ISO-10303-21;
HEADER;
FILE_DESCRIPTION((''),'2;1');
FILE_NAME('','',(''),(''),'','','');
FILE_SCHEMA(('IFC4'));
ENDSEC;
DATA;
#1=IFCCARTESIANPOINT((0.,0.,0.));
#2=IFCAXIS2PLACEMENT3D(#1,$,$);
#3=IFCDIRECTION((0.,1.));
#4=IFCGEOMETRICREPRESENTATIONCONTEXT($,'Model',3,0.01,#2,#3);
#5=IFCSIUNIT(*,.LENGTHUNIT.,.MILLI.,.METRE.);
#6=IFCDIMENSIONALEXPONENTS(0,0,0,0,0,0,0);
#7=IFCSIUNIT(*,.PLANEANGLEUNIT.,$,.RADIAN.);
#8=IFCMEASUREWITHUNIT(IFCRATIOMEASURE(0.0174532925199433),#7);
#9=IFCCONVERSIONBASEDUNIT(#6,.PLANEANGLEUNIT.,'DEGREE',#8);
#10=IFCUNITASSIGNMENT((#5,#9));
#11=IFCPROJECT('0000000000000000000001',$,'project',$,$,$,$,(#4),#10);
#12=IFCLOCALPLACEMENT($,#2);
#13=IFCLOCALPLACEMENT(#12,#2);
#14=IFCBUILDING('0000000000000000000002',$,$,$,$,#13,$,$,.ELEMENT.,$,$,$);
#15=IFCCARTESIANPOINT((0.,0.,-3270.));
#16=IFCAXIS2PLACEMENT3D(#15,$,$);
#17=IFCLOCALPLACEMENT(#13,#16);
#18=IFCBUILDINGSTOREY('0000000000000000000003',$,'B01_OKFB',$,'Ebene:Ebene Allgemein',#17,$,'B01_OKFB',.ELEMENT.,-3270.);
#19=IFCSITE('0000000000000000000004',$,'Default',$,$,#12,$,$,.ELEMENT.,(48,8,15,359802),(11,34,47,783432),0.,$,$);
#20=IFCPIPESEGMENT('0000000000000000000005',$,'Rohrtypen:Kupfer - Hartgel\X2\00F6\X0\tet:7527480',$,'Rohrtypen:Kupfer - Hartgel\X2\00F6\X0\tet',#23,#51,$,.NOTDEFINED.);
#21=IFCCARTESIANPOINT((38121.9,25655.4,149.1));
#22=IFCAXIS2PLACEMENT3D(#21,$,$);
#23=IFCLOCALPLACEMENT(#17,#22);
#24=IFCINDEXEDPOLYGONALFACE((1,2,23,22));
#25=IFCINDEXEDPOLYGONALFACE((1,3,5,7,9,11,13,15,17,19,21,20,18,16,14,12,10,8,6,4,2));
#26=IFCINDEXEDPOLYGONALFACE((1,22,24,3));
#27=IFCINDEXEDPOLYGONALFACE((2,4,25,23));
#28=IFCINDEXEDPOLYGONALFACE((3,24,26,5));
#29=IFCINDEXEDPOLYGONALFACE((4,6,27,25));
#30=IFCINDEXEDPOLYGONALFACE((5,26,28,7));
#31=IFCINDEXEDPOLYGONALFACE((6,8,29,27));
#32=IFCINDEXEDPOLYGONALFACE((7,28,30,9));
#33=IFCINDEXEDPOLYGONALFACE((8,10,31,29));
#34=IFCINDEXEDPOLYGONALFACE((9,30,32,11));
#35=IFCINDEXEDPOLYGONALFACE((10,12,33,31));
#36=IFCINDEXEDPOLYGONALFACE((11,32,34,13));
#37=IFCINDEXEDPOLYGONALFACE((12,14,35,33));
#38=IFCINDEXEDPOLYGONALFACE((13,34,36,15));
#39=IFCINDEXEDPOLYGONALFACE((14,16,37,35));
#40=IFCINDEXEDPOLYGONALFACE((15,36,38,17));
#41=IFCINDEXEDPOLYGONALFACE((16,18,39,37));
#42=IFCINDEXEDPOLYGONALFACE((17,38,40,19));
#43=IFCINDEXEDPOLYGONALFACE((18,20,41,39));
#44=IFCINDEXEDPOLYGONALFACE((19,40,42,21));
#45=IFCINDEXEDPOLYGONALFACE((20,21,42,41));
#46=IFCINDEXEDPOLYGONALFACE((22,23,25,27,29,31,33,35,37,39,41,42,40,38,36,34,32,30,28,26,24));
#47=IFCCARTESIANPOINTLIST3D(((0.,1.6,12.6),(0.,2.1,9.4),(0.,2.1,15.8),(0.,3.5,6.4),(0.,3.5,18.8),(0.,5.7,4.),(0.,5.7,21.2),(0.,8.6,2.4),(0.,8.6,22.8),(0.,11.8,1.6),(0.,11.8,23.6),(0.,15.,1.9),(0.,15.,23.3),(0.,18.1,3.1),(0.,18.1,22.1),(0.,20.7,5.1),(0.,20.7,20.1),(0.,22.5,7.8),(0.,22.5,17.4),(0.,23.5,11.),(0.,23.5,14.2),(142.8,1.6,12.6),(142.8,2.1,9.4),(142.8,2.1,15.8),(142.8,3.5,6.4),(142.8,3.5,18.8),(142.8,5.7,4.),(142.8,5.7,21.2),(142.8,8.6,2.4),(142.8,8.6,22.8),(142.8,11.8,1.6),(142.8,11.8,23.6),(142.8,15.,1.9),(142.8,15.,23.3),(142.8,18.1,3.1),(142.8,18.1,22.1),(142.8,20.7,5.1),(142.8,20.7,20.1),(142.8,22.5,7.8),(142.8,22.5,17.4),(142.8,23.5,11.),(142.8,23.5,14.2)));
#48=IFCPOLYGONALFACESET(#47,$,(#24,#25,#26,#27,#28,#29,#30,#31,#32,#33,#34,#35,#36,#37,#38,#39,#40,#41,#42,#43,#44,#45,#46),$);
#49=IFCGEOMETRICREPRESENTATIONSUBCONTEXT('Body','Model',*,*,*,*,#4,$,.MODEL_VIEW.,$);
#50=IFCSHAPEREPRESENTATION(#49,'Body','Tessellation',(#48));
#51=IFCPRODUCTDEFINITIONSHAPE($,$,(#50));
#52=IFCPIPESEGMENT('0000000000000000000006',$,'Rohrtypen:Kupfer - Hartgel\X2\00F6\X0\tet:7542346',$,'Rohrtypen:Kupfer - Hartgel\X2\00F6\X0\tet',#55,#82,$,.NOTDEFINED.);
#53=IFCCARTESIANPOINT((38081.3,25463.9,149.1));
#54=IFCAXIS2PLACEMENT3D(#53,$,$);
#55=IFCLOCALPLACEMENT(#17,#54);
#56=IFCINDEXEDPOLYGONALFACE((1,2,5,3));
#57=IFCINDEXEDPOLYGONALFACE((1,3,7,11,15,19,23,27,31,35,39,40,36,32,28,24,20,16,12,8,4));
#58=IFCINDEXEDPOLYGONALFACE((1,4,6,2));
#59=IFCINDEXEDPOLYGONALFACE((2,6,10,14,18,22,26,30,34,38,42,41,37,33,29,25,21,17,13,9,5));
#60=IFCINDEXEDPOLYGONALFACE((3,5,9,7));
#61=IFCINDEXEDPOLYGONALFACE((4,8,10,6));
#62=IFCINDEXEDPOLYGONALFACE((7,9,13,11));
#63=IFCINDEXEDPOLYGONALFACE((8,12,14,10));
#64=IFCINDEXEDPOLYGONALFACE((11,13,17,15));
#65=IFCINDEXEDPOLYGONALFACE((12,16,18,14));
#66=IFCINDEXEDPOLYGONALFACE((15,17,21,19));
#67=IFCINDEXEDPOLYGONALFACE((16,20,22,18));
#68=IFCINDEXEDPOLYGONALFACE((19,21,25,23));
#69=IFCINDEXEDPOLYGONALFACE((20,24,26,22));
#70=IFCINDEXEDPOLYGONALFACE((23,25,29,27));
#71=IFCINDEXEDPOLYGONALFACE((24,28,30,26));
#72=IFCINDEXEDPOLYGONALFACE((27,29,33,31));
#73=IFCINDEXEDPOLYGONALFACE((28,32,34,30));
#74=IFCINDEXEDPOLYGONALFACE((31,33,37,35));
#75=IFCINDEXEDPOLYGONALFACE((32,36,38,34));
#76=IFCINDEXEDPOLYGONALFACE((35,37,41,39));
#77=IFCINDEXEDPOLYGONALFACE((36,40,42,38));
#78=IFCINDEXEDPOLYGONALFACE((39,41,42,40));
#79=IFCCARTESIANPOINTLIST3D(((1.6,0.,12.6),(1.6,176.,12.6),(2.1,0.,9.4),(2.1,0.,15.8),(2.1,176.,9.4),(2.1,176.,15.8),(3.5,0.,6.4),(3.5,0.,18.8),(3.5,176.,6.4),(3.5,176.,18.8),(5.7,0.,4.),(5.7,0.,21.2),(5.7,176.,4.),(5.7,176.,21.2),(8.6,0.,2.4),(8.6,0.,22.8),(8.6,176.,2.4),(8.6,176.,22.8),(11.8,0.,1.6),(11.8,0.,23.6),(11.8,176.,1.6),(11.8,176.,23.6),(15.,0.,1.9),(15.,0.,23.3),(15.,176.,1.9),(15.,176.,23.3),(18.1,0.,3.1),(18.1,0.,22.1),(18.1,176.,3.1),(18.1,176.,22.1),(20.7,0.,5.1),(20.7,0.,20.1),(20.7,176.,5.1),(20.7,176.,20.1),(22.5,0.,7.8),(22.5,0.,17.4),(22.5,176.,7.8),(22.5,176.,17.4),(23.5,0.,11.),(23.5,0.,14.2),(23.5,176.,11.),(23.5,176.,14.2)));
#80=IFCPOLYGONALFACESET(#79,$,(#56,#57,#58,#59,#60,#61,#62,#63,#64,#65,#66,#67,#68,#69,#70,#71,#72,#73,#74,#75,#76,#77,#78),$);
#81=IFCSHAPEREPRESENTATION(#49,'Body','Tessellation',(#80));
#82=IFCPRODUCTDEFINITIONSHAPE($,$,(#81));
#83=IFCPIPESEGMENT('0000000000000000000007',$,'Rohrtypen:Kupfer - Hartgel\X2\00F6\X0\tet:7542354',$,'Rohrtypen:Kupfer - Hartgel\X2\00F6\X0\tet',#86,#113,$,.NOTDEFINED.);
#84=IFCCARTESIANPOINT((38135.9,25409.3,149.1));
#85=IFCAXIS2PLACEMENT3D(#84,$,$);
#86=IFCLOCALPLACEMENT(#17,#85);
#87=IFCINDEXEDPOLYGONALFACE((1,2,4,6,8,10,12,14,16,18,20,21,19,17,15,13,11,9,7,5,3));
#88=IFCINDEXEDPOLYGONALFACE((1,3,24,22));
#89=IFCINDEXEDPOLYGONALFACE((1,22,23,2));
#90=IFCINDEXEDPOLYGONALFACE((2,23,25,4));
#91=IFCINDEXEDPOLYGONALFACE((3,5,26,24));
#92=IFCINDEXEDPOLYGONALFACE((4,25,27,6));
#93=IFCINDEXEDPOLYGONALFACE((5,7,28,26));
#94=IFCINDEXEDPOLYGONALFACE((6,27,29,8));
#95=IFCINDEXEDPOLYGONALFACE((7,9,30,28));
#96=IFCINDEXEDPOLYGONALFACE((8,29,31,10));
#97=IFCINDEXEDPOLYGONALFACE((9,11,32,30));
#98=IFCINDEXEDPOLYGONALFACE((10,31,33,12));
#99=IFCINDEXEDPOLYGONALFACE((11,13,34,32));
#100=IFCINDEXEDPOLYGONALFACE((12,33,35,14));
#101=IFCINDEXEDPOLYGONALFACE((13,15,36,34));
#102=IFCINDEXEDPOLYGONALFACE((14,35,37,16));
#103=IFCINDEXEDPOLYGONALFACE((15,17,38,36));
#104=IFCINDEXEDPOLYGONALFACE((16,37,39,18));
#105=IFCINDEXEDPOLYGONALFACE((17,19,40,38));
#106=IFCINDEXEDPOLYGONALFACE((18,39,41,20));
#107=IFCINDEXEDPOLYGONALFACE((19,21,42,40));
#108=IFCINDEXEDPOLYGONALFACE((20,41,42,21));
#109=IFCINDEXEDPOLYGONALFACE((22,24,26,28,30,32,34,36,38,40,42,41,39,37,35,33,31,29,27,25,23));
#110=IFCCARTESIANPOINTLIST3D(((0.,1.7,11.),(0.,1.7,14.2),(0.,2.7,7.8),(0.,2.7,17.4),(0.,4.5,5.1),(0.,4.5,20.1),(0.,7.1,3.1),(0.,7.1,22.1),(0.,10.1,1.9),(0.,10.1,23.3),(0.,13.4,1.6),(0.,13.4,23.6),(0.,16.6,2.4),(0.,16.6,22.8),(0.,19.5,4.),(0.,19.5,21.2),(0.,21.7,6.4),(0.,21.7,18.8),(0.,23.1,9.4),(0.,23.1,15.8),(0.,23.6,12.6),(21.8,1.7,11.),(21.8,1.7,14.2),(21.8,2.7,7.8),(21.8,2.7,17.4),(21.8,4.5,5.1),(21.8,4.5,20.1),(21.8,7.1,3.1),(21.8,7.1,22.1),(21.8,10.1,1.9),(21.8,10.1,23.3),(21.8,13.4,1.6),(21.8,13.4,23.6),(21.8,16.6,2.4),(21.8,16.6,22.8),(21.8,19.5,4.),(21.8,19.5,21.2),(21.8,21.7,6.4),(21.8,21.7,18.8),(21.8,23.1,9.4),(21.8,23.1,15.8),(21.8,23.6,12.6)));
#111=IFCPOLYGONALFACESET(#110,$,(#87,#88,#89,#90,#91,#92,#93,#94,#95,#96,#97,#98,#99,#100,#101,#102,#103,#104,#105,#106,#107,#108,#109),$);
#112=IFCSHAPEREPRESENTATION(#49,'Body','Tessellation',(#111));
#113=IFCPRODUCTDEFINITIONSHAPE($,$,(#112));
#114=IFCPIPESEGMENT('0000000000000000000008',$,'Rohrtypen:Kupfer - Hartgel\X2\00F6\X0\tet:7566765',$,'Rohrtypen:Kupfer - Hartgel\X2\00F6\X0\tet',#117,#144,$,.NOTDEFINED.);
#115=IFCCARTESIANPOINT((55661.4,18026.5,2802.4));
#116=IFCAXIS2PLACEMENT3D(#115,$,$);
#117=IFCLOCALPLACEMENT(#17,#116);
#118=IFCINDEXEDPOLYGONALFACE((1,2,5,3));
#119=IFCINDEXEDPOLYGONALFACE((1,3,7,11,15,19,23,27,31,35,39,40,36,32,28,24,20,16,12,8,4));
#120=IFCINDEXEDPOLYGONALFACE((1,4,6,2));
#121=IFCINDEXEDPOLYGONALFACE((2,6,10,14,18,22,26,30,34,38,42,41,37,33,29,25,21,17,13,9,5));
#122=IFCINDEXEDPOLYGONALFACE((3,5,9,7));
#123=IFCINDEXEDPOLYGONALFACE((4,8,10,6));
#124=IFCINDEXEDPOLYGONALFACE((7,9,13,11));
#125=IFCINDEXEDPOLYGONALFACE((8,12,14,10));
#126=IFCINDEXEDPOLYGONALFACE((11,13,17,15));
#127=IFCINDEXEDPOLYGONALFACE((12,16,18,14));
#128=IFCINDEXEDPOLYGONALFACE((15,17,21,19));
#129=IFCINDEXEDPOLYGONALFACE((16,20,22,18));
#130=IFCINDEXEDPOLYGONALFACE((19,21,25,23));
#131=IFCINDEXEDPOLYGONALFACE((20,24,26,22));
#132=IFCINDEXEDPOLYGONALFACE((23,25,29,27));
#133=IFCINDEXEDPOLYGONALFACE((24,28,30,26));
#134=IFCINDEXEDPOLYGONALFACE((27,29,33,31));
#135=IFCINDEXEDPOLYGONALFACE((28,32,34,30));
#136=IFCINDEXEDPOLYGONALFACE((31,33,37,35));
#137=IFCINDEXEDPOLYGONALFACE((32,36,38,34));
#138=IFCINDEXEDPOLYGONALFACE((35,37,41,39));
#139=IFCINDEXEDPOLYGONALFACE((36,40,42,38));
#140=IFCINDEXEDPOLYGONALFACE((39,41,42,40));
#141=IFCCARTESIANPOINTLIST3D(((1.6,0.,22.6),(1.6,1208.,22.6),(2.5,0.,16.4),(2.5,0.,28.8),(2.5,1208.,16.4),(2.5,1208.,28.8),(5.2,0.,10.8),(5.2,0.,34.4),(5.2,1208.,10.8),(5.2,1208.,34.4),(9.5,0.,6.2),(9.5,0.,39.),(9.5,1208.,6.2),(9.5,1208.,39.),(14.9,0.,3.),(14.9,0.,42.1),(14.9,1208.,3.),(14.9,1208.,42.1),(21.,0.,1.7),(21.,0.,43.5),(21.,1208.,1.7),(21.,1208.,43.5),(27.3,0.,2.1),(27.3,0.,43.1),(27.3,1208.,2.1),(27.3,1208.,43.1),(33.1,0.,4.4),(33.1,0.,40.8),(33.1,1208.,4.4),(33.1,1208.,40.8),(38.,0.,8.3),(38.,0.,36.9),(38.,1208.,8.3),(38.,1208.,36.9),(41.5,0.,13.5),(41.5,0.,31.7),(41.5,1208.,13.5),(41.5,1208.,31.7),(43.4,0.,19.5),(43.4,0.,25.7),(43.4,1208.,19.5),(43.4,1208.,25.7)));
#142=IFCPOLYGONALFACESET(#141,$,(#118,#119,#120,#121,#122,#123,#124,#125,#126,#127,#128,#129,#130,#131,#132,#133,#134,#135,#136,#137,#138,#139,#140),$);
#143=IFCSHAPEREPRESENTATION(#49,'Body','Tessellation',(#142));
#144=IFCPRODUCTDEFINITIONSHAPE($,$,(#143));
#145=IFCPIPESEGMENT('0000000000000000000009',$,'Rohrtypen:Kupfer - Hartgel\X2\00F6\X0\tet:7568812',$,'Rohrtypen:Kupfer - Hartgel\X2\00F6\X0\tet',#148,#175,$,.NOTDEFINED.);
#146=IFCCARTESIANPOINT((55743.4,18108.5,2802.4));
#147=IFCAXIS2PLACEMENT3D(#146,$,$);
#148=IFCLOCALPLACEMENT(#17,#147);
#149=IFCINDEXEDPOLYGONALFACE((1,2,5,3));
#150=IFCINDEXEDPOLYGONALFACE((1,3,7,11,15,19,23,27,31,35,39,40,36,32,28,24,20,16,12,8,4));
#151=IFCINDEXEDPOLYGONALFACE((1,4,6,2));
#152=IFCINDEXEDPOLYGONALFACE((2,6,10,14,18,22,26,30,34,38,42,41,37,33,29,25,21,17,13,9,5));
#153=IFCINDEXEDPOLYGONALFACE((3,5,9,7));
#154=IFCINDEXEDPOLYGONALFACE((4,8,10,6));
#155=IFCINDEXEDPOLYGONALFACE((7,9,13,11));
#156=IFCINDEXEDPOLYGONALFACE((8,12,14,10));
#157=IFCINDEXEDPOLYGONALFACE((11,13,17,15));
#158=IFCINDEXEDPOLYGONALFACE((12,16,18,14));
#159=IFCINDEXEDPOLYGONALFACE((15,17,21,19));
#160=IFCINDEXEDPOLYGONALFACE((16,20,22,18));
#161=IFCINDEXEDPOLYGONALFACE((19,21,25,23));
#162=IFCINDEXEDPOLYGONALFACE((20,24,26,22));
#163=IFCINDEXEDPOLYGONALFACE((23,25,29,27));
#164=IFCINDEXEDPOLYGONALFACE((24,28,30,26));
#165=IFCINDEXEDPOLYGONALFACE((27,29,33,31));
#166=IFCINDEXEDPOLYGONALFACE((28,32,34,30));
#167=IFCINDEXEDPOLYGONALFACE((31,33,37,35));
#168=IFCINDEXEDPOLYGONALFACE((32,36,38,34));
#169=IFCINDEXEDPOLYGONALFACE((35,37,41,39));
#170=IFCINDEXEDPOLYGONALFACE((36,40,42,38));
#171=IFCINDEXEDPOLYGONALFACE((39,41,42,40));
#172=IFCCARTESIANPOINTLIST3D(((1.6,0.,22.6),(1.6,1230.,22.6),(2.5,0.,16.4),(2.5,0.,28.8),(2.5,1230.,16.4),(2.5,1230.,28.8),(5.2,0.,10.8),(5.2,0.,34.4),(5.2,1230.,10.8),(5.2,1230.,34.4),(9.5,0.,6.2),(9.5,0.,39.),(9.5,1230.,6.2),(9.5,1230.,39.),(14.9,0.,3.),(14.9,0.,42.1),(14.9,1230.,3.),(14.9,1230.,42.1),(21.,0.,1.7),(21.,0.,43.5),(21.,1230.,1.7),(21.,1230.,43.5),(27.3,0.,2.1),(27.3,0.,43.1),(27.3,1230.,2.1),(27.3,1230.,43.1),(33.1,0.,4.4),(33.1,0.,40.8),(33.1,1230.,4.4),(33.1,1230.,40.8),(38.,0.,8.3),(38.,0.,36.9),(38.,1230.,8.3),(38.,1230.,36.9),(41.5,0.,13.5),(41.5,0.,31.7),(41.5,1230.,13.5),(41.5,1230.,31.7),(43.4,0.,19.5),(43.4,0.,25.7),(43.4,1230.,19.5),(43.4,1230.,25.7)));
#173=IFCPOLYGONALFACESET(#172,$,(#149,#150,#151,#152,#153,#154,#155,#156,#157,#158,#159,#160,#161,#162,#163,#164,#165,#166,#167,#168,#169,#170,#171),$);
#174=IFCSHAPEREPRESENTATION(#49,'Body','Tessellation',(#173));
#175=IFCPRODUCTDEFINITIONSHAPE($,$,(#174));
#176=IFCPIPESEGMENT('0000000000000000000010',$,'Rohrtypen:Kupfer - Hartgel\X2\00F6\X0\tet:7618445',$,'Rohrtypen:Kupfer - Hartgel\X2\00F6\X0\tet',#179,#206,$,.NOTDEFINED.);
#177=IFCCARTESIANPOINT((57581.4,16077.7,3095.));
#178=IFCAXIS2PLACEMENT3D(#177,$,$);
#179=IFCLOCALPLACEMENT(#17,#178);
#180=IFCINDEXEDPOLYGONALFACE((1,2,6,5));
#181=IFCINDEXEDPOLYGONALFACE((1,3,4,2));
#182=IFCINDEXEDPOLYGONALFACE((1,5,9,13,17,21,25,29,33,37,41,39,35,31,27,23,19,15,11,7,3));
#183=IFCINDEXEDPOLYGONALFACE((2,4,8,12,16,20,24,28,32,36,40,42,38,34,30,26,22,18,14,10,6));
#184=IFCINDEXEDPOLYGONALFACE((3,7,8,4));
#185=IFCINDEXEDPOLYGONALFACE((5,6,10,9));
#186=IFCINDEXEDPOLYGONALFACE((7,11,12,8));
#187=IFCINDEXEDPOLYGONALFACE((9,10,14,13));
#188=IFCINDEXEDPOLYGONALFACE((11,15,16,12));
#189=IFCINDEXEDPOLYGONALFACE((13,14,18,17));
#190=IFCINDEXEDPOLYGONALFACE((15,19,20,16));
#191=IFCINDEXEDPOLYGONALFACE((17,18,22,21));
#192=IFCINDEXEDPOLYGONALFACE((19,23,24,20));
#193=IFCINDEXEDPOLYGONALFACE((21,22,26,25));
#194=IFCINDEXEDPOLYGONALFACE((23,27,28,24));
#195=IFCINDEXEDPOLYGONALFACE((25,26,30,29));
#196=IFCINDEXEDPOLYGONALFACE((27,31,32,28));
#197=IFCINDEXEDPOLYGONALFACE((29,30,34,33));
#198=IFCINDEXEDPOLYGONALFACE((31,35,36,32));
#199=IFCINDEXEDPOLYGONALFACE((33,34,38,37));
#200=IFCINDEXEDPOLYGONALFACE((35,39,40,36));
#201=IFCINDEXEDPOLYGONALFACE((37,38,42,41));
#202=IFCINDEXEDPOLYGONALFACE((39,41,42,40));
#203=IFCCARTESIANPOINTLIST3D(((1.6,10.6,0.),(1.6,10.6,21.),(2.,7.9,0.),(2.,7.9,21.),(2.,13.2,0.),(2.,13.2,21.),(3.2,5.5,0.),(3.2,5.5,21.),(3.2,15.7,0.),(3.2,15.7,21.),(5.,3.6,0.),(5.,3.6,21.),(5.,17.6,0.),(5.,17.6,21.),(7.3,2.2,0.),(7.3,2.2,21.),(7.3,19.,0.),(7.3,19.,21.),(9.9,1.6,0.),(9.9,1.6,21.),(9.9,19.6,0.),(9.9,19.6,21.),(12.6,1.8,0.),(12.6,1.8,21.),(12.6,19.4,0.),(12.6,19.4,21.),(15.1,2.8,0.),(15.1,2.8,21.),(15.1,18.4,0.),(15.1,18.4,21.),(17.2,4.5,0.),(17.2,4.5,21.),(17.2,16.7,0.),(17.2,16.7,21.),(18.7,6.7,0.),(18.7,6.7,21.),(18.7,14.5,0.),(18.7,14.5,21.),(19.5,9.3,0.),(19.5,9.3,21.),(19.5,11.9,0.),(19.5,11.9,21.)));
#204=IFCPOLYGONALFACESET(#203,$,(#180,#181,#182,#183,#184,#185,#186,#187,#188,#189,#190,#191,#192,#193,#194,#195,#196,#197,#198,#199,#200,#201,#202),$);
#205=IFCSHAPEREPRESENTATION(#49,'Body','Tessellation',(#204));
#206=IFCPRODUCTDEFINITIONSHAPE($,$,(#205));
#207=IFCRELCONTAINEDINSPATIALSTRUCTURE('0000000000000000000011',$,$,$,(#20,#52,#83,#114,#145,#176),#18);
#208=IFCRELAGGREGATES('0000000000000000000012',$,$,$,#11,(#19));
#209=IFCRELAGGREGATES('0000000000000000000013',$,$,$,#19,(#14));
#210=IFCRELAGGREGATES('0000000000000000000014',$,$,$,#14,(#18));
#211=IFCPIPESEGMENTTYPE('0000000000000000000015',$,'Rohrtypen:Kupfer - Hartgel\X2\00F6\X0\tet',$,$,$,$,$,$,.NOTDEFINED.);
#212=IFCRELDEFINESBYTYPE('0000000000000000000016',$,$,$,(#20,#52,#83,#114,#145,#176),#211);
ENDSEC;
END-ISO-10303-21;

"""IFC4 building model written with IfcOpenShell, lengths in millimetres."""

from ifc_helpers import new_model, entity, si_unit, converted_unit, direction, frame, frame_2d, origin, origin_2d_with_axis, place, context, subcontext, project, spatial, circle, extrude, type_object, element, save


model = new_model("IFC4")

# Units and contexts
model_context = context("Model", 3, precision=0.01, world=origin(), true_north=direction((0.0, 1.0)))
body_context = subcontext(model_context, "Body", "Model", "MODEL_VIEW")
ifc_project = project(units=[si_unit("LENGTHUNIT", "METRE", prefix="MILLI"), converted_unit("PLANEANGLEUNIT", "DEGREE", entity("IfcRatioMeasure", 0.0174532925199433), si_unit("PLANEANGLEUNIT", "RADIAN"), dimensions=[0, 0, 0, 0, 0, 0, 0])], contexts=[model_context])

# Site, building, storey
site_placement = place(None, origin())
site = spatial("IfcSite", under=ifc_project, at=site_placement, Name="Default", CompositionType="ELEMENT", RefLatitude=(48, 8, 15, 359802), RefLongitude=(11, 34, 47, 783432), RefElevation=0.0)
building_placement = place(site_placement, origin())
building = spatial("IfcBuilding", under=site, at=building_placement, CompositionType="ELEMENT")
storey_placement = place(building_placement, frame((0.0, 0.0, -3270.0)))
storey = spatial("IfcBuildingStorey", under=building, at=storey_placement, Name="B01_OKFB", ObjectType="Ebene:Ebene Allgemein", LongName="B01_OKFB", CompositionType="ELEMENT", Elevation=-3270.0)

# Pipe segments
pipe_segment_type = type_object("IfcPipeSegmentType", Name="Rohrtypen:Kupfer - Hartgelötet", PredefinedType="NOTDEFINED")
pipe_segment_1_placement = place(storey_placement, frame((38121.9, 25655.4, 149.1)))
element("IfcPipeSegment", 1, at=pipe_segment_1_placement, inside=storey, type_object=pipe_segment_type, Name="Rohrtypen:Kupfer - Hartgelötet:7527480", ObjectType="Rohrtypen:Kupfer - Hartgelötet", PredefinedType="NOTDEFINED", context=body_context, shape_type="SweptSolid", body=[
    extrude(circle(Radius=11.0, at=frame_2d((0.0, 0.0), x_axis=(1.0, 0.0))), frame((0.0, 12.6, 12.6), z_axis=(1.0, 0.0, 0.0), x_axis=(0.0, -1.0, 0.0)), (0.0, 0.0, 1.0), 142.8),
])
pipe_segment_2_placement = place(storey_placement, frame((38081.3, 25463.9, 149.1)))
element("IfcPipeSegment", 2, at=pipe_segment_2_placement, inside=storey, type_object=pipe_segment_type, Name="Rohrtypen:Kupfer - Hartgelötet:7542346", ObjectType="Rohrtypen:Kupfer - Hartgelötet", PredefinedType="NOTDEFINED", context=body_context, shape_type="SweptSolid", body=[
    extrude(circle(Radius=11.0, at=origin_2d_with_axis()), frame((12.6, 0.0, 12.6), z_axis=(0.0, 1.0, 0.0), x_axis=(-1.0, 0.0, 0.0)), (0.0, 0.0, 1.0), 176.0),
])
pipe_segment_3_placement = place(storey_placement, frame((38135.9, 25409.3, 149.1)))
element("IfcPipeSegment", 3, at=pipe_segment_3_placement, inside=storey, type_object=pipe_segment_type, Name="Rohrtypen:Kupfer - Hartgelötet:7542354", ObjectType="Rohrtypen:Kupfer - Hartgelötet", PredefinedType="NOTDEFINED", context=body_context, shape_type="SweptSolid", body=[
    extrude(circle(Radius=11.0, at=frame_2d((0.0, 0.0), x_axis=(1.0, 0.0))), frame((0.0, 12.6, 12.6), z_axis=(1.0, 0.0, 0.0), x_axis=(0.0, 1.0, 0.0)), (0.0, 0.0, 1.0), 21.8),
])
pipe_segment_4_placement = place(storey_placement, frame((55661.4, 18026.5, 2802.4)))
element("IfcPipeSegment", 4, at=pipe_segment_4_placement, inside=storey, type_object=pipe_segment_type, Name="Rohrtypen:Kupfer - Hartgelötet:7566765", ObjectType="Rohrtypen:Kupfer - Hartgelötet", PredefinedType="NOTDEFINED", context=body_context, shape_type="SweptSolid", body=[
    extrude(circle(Radius=21.0, at=origin_2d_with_axis()), frame((22.6, 0.0, 22.6), z_axis=(0.0, 1.0, 0.0), x_axis=(-1.0, 0.0, 0.0)), (0.0, 0.0, 1.0), 1208.0),
])
pipe_segment_5_placement = place(storey_placement, frame((55743.4, 18108.5, 2802.4)))
element("IfcPipeSegment", 5, at=pipe_segment_5_placement, inside=storey, type_object=pipe_segment_type, Name="Rohrtypen:Kupfer - Hartgelötet:7568812", ObjectType="Rohrtypen:Kupfer - Hartgelötet", PredefinedType="NOTDEFINED", context=body_context, shape_type="SweptSolid", body=[
    extrude(circle(Radius=21.0, at=origin_2d_with_axis()), frame((22.6, 0.0, 22.6), z_axis=(0.0, 1.0, 0.0), x_axis=(-1.0, 0.0, 0.0)), (0.0, 0.0, 1.0), 1230.0),
])
pipe_segment_6_placement = place(storey_placement, frame((57581.4, 16077.7, 3095.0)))
element("IfcPipeSegment", 6, at=pipe_segment_6_placement, inside=storey, type_object=pipe_segment_type, Name="Rohrtypen:Kupfer - Hartgelötet:7618445", ObjectType="Rohrtypen:Kupfer - Hartgelötet", PredefinedType="NOTDEFINED", context=body_context, shape_type="SweptSolid", body=[
    extrude(circle(Radius=9.0, at=frame_2d((0.0, 0.0), x_axis=(1.0, 0.0))), frame((10.6, 10.6, 0.0), z_axis=(0.0, 0.0, 1.0), x_axis=(-1.0, 0.0, 0.0)), (0.0, 0.0, 1.0), 21.0),
])

save(model, "model.ifc")
